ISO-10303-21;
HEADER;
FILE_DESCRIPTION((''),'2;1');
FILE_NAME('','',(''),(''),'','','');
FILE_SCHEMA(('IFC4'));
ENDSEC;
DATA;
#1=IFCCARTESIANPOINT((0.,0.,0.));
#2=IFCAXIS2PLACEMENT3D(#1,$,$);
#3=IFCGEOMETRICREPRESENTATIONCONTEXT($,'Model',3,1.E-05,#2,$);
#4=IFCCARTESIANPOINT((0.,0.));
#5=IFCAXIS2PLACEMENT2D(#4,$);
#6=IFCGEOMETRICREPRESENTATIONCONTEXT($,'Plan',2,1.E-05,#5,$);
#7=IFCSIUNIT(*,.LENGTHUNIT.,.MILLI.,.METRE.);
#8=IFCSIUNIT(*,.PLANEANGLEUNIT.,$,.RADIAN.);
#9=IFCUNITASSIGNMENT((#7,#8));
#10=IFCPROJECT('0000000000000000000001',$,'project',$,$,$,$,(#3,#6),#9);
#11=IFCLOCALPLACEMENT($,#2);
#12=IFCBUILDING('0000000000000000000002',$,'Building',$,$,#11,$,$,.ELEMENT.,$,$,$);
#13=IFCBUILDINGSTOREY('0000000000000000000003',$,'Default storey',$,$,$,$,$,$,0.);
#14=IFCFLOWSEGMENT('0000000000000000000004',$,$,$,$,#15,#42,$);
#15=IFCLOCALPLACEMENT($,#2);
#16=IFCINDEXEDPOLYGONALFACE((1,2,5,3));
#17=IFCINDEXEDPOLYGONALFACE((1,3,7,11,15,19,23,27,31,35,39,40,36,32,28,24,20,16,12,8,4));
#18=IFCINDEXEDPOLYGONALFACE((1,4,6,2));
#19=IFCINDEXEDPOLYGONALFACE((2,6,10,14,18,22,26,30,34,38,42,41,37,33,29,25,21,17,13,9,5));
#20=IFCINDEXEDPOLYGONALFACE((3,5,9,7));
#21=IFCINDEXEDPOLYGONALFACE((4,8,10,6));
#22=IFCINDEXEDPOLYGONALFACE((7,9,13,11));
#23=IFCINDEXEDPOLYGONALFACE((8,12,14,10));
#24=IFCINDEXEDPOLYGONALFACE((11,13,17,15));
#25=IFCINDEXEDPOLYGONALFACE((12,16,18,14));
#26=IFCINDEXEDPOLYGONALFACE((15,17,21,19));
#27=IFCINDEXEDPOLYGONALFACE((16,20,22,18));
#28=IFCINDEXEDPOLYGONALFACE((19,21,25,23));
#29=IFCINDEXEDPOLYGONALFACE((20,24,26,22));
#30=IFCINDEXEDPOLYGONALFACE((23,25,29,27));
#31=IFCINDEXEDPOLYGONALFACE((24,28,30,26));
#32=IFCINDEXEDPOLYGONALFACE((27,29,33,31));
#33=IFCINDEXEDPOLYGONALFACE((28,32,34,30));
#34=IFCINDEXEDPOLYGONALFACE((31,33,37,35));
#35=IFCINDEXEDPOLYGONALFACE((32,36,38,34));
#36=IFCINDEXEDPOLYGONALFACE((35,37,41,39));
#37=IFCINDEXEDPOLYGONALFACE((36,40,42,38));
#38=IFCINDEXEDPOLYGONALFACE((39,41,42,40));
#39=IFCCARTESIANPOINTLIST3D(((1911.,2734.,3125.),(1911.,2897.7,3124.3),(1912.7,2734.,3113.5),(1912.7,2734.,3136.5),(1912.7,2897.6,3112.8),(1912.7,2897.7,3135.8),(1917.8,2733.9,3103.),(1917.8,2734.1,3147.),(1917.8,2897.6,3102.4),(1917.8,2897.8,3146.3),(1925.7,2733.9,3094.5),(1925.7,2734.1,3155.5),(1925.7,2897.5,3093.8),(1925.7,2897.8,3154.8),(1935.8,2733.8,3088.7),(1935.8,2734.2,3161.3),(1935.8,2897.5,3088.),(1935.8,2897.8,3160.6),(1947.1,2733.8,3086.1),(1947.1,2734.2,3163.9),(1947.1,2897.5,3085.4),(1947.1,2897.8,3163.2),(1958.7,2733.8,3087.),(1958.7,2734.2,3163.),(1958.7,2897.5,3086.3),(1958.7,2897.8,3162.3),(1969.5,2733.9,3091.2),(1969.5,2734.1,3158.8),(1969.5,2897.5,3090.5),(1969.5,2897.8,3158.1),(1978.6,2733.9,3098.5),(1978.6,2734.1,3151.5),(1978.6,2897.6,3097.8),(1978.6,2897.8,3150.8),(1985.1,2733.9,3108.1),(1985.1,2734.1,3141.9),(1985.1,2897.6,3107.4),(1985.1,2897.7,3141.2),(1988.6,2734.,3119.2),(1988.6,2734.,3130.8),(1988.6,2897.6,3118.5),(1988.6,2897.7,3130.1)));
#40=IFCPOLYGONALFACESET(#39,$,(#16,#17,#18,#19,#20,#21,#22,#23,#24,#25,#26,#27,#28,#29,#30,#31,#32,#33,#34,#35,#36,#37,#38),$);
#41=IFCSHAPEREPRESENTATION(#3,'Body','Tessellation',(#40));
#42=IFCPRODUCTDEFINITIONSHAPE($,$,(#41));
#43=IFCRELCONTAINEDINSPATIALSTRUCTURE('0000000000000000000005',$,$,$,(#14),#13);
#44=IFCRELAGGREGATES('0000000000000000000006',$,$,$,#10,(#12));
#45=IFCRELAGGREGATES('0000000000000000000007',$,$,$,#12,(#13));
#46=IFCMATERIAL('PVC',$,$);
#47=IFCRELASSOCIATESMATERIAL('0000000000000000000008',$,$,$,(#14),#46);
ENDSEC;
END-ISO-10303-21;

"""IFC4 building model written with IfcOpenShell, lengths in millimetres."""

from ifc_helpers import new_model, si_unit, frame, origin, origin_2d, place, context, project, spatial, circle, extrude, material, element, save


model = new_model("IFC4")

# Units and contexts
model_context = context("Model", 3, precision=1e-05, world=origin())
plan_context = context("Plan", 2, precision=1e-05, world=origin_2d())
ifc_project = project(units=[si_unit("LENGTHUNIT", "METRE", prefix="MILLI"), si_unit("PLANEANGLEUNIT", "RADIAN")], contexts=[model_context, plan_context])

# Building, storey
placement = place(None, origin())
building = spatial("IfcBuilding", under=ifc_project, at=placement, Name="Building", CompositionType="ELEMENT")
storey = spatial("IfcBuildingStorey", under=building, Name="Default storey", Elevation=0.0)

# Flow segment
ifc_material = material(Name="PVC")
element("IfcFlowSegment", 1, at=placement, inside=storey, material=ifc_material, context=model_context, shape_type="SweptSolid", body=[
    extrude(circle(Radius=39.0, at=origin_2d()), frame((1950.0, 2897.7, 3124.3), z_axis=(0.0, -163.667332, 0.679118), x_axis=(-163667.332395, 0.0, 0.0)), (0.0, 0.0, 1.0), 163.7),
])

save(model, "model.ifc")
